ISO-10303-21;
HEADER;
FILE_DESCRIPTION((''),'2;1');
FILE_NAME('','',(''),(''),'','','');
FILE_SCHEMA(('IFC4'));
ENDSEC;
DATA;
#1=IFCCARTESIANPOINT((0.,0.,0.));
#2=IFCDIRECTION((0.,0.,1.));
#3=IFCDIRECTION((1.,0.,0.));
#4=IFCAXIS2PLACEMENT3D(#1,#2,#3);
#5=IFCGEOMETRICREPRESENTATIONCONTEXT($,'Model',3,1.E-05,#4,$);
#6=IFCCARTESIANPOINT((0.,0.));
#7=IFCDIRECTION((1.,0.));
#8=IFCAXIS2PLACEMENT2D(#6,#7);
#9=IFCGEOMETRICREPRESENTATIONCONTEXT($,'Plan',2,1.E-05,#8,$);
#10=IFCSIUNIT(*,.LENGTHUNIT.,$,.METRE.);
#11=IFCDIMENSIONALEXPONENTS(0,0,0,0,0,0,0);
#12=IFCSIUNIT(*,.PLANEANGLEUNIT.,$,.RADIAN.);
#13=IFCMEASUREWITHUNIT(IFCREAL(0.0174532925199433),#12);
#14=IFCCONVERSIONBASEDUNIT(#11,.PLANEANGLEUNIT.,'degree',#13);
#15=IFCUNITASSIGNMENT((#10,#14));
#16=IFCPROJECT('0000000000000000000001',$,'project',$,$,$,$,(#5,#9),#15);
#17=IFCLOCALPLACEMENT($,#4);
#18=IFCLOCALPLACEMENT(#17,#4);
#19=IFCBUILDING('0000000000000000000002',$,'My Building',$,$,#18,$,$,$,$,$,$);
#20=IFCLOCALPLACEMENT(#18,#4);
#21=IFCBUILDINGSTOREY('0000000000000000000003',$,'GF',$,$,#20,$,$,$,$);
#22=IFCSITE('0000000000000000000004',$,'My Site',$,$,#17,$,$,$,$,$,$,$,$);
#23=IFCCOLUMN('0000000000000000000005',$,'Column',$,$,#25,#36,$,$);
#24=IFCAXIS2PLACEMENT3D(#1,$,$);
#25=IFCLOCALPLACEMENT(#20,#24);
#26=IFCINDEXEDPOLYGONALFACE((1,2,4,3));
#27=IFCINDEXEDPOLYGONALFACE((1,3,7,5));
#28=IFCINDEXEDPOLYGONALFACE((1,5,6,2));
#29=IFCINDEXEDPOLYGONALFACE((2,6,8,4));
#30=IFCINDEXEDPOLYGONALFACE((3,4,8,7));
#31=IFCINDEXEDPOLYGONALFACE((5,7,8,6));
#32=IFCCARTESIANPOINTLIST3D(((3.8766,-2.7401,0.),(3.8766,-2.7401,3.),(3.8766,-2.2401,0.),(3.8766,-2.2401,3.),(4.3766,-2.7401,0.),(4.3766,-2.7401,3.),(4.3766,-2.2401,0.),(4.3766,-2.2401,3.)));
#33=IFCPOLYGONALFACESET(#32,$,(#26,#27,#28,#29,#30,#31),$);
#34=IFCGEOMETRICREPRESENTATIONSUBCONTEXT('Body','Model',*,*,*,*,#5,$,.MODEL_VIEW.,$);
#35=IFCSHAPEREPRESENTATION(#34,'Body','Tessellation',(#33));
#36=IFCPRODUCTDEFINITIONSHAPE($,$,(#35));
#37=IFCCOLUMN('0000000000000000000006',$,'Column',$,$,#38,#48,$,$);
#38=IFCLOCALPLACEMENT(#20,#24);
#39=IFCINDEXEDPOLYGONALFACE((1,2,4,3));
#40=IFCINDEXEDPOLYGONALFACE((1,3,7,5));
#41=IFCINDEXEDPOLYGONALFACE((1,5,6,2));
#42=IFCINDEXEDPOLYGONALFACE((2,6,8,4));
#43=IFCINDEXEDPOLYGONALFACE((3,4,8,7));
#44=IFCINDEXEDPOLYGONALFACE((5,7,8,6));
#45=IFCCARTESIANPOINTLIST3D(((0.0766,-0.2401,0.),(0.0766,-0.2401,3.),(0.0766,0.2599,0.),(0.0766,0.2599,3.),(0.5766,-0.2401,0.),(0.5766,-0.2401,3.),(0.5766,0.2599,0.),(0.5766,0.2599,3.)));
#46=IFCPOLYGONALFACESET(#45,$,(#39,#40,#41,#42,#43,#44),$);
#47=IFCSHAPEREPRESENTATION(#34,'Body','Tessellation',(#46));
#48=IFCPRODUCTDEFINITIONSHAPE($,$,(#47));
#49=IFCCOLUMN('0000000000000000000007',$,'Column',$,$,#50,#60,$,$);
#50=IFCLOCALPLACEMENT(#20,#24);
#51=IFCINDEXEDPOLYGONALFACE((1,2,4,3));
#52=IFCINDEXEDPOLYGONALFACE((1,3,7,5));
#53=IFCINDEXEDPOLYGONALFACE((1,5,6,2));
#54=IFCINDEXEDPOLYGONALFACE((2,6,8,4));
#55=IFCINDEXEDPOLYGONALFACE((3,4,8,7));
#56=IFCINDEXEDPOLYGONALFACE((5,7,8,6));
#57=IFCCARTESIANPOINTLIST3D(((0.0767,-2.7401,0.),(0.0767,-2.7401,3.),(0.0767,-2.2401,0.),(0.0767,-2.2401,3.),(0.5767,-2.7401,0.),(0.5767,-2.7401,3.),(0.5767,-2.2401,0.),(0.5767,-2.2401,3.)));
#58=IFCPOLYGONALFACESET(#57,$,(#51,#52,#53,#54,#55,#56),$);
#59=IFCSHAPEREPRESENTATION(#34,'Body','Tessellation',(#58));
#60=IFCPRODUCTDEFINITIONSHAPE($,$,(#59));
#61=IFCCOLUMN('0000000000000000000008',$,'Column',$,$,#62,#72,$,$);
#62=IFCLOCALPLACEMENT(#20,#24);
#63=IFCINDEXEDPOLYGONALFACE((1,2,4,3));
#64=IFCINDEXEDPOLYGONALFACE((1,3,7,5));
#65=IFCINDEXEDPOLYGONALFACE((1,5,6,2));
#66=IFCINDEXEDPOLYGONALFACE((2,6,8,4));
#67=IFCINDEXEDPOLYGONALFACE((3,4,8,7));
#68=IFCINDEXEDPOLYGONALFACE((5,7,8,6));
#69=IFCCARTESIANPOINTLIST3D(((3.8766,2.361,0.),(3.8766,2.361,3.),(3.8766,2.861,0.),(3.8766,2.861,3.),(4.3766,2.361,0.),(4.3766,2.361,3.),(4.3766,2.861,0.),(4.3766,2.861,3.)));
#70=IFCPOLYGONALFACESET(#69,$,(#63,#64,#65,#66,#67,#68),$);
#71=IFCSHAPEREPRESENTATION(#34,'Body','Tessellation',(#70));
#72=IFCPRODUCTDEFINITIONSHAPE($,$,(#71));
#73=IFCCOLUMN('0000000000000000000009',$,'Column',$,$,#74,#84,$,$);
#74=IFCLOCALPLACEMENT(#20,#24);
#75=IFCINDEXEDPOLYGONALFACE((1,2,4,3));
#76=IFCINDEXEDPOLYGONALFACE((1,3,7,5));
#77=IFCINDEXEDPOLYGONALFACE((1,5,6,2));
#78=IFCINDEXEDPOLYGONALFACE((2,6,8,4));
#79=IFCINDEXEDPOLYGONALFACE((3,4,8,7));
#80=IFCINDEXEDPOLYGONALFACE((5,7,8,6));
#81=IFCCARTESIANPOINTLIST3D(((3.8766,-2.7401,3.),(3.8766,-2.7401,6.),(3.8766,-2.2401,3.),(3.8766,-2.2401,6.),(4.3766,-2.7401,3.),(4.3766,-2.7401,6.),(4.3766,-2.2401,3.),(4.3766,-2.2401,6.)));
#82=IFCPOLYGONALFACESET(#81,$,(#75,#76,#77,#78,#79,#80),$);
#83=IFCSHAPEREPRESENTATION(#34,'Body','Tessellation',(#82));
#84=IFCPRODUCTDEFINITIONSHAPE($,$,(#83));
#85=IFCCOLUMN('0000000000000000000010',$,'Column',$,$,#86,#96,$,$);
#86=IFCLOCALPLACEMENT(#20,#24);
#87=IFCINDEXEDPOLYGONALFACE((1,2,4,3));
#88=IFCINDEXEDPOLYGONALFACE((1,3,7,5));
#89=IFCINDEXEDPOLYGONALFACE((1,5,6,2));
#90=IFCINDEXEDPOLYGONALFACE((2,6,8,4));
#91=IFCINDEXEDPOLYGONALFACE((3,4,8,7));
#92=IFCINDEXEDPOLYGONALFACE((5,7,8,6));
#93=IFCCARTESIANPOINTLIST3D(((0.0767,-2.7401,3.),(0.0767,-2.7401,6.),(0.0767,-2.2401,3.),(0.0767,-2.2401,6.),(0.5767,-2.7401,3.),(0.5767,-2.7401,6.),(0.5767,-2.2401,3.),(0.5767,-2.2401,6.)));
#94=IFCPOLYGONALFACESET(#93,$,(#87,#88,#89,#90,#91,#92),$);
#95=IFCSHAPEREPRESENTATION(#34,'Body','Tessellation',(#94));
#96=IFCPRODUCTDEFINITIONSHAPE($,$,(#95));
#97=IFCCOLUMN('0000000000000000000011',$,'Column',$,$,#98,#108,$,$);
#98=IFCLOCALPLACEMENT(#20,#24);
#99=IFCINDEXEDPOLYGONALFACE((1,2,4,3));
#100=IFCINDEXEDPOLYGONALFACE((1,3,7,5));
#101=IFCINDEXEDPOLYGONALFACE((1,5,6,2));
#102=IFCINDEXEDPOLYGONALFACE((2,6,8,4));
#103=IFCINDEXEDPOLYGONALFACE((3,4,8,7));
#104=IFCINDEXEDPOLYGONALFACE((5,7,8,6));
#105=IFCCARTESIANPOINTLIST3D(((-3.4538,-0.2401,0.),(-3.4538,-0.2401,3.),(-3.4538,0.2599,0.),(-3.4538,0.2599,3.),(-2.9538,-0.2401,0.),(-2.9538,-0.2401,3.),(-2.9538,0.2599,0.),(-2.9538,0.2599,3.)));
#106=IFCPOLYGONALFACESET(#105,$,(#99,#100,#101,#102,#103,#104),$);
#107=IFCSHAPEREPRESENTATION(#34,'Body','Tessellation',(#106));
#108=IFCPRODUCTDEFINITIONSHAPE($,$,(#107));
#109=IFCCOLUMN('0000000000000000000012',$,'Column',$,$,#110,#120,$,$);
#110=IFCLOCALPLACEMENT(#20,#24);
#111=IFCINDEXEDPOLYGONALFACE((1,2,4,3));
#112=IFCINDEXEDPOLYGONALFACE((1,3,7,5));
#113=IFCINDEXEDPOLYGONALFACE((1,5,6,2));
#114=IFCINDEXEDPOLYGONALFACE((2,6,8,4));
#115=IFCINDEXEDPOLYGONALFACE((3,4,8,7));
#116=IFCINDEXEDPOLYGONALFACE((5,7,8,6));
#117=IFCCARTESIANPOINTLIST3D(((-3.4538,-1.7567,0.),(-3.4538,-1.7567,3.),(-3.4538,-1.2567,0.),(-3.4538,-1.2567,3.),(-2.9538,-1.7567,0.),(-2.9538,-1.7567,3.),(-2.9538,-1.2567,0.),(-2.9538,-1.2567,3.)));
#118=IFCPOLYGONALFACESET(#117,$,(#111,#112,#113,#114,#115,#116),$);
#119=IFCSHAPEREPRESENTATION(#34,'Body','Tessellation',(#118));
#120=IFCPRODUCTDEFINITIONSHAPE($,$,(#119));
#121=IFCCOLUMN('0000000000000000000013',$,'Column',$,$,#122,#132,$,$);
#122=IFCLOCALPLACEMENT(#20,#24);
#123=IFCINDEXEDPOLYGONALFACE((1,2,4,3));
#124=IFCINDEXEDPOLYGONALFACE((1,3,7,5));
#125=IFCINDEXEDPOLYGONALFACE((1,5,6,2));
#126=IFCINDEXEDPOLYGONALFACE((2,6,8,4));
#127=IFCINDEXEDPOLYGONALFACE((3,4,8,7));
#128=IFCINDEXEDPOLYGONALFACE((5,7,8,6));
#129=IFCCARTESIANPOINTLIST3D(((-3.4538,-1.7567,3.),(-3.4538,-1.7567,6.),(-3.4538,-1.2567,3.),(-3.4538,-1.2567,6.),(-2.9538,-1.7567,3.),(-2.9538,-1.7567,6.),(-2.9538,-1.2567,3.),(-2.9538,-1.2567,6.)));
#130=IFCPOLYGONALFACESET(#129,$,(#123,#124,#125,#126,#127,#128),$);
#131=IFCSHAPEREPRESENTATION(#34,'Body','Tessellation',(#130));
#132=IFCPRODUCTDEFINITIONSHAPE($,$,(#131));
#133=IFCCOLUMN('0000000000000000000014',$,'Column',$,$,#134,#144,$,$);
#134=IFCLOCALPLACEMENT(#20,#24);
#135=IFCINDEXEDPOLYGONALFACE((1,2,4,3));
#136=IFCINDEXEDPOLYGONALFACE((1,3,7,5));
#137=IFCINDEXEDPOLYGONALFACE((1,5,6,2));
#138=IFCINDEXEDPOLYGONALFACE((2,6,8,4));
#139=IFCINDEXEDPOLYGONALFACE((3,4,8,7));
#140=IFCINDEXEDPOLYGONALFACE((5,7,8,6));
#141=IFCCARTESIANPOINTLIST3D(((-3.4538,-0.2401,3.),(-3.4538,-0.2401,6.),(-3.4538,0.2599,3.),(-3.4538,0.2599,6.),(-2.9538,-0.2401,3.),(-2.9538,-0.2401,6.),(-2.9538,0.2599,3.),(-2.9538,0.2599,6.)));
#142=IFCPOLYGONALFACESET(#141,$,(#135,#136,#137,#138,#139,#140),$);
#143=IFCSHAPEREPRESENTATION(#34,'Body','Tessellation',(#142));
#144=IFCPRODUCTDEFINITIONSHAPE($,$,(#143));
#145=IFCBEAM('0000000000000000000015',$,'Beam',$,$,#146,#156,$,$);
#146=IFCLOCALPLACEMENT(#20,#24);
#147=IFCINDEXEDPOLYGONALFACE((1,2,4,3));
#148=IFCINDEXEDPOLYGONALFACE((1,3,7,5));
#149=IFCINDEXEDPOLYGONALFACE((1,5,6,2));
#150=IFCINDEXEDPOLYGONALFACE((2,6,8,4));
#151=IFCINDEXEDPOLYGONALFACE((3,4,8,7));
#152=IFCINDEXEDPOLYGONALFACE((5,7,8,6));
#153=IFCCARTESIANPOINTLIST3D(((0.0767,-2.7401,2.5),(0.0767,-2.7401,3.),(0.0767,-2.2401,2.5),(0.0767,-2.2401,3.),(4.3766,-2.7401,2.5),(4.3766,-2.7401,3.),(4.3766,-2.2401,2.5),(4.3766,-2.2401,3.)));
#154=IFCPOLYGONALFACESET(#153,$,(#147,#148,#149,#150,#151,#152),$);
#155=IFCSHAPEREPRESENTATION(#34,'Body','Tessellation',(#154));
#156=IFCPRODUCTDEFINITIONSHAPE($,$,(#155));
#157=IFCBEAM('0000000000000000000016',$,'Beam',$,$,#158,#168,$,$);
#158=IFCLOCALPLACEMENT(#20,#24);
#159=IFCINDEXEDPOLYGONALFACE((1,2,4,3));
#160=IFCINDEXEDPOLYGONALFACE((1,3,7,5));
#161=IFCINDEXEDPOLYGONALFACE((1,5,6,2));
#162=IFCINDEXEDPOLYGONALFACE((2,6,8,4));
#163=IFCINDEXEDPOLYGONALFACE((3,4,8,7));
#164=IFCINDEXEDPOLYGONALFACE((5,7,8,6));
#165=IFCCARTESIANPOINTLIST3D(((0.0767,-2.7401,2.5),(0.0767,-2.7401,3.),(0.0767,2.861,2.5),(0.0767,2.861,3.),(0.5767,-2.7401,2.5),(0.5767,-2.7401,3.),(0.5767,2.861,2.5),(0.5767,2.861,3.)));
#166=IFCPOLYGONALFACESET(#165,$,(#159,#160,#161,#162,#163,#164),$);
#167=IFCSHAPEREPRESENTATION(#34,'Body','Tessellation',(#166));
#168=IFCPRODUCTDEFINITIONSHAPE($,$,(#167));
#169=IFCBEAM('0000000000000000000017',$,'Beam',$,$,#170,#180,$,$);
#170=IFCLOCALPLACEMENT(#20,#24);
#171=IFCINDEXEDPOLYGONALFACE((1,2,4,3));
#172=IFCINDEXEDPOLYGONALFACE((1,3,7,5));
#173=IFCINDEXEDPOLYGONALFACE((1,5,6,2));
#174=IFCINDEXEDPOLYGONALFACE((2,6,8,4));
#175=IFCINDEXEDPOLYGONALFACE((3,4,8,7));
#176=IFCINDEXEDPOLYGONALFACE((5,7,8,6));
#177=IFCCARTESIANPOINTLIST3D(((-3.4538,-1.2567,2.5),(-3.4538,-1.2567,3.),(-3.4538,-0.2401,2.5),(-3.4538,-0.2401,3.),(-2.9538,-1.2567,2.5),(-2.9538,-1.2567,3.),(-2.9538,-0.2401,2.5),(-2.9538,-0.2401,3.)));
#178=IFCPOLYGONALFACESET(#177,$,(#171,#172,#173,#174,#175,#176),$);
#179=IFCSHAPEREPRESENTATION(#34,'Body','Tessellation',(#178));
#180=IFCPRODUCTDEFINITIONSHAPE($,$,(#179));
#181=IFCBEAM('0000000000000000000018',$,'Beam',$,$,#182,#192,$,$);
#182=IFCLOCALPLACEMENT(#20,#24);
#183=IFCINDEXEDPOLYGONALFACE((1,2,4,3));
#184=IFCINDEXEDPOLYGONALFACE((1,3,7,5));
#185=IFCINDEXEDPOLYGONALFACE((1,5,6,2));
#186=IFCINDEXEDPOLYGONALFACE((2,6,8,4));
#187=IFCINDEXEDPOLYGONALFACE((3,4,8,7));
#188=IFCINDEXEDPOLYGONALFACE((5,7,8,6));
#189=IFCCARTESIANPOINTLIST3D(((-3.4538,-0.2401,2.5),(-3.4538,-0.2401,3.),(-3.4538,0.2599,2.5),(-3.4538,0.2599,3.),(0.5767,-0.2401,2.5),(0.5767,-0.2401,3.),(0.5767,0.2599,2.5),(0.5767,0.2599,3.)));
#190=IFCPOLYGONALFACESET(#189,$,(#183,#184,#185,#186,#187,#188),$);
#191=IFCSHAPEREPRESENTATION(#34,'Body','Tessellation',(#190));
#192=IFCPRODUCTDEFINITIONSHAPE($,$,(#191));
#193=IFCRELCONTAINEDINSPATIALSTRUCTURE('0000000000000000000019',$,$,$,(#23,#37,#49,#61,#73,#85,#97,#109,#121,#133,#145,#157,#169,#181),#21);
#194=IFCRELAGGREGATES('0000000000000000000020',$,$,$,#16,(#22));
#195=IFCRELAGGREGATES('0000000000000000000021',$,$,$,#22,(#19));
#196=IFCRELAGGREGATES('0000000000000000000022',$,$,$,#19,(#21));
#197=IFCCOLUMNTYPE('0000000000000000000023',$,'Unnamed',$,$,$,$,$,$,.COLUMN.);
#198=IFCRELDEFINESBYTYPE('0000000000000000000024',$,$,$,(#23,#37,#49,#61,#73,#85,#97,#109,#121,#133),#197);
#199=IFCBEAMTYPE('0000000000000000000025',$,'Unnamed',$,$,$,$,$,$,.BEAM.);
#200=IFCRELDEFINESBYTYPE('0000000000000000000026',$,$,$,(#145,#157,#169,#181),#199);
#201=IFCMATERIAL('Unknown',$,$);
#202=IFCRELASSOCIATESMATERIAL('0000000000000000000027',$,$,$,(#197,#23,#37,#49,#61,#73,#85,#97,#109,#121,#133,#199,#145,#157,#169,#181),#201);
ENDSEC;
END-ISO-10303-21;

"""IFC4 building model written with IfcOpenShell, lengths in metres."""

from ifc_helpers import new_model, entity, si_unit, converted_unit, frame, origin_with_axes, origin_2d_with_axis, place, context, subcontext, project, spatial, rectangle, extrude, material, material_profile, profile_set, profile_usage, type_object, element, save


model = new_model("IFC4")

# Units and contexts
model_context = context("Model", 3, precision=1e-05, world=origin_with_axes())
plan_context = context("Plan", 2, precision=1e-05, world=origin_2d_with_axis())
body_context_1 = subcontext(model_context, "Body", "Model", "MODEL_VIEW")
ifc_project = project(units=[si_unit("LENGTHUNIT", "METRE"), converted_unit("PLANEANGLEUNIT", "degree", entity("IfcReal", 0.0174532925199433), si_unit("PLANEANGLEUNIT", "RADIAN"), dimensions=[0, 0, 0, 0, 0, 0, 0])], contexts=[model_context, plan_context])

# Site, building, storey
site_placement = place(None, origin_with_axes())
site = spatial("IfcSite", under=ifc_project, at=site_placement, Name="My Site")
building_placement = place(site_placement, origin_with_axes())
building = spatial("IfcBuilding", under=site, at=building_placement, Name="My Building")
storey_placement = place(building_placement, origin_with_axes())
storey = spatial("IfcBuildingStorey", under=building, at=storey_placement, Name="GF")

# Columns
ifc_material_1 = material(Name="Unknown")
ifc_material_profile_1 = material_profile(ifc_material_1, rectangle(XDim=0.5, YDim=0.5))
ifc_profile_set_1 = profile_set([ifc_material_profile_1])
ifc_profile_usage_1 = profile_usage(ifc_profile_set_1, cardinal=5)
column_type = type_object("IfcColumnType", Name="Unnamed", PredefinedType="COLUMN", material=ifc_profile_set_1)
column_1_placement = place(storey_placement, frame((4.1266, -2.4901, 0.0), z_axis=(0.0, 0.0, 1.0), x_axis=(1.0, 0.0, 0.0)))
element("IfcColumn", 1, at=column_1_placement, inside=storey, type_object=column_type, material=ifc_profile_usage_1, Name="Column", context=body_context_1, shape_type="SweptSolid", body=[
    extrude(rectangle(XDim=0.5, YDim=0.5), origin_with_axes(), (0.0, 0.0, 1.0), 3.0),
])
ifc_profile_usage_2 = profile_usage(ifc_profile_set_1, cardinal=5)
column_2_placement = place(storey_placement, frame((0.3266, 0.0099, 0.0), z_axis=(0.0, 0.0, 1.0), x_axis=(1.0, 0.0, 0.0)))
element("IfcColumn", 2, at=column_2_placement, inside=storey, type_object=column_type, material=ifc_profile_usage_2, Name="Column", context=body_context_1, shape_type="SweptSolid", body=[
    extrude(rectangle(XDim=0.5, YDim=0.5), origin_with_axes(), (0.0, 0.0, 1.0), 3.0),
])
ifc_profile_usage_3 = profile_usage(ifc_profile_set_1, cardinal=5)
column_3_placement = place(storey_placement, frame((0.3267, -2.4901, 0.0), z_axis=(0.0, 0.0, 1.0), x_axis=(1.0, 0.0, 0.0)))
element("IfcColumn", 3, at=column_3_placement, inside=storey, type_object=column_type, material=ifc_profile_usage_3, Name="Column", context=body_context_1, shape_type="SweptSolid", body=[
    extrude(rectangle(XDim=0.5, YDim=0.5), origin_with_axes(), (0.0, 0.0, 1.0), 3.0),
])
ifc_profile_usage_4 = profile_usage(ifc_profile_set_1, cardinal=5)
column_4_placement = place(storey_placement, frame((4.1266, 2.611, 0.0), z_axis=(0.0, 0.0, 1.0), x_axis=(1.0, 0.0, 0.0)))
element("IfcColumn", 4, at=column_4_placement, inside=storey, type_object=column_type, material=ifc_profile_usage_4, Name="Column", context=body_context_1, shape_type="SweptSolid", body=[
    extrude(rectangle(XDim=0.5, YDim=0.5), origin_with_axes(), (0.0, 0.0, 1.0), 3.0),
])
ifc_profile_usage_5 = profile_usage(ifc_profile_set_1, cardinal=5)
column_5_placement = place(storey_placement, frame((4.1266, -2.4901, 3.0), z_axis=(0.0, 0.0, 1.0), x_axis=(1.0, 0.0, 0.0)))
element("IfcColumn", 5, at=column_5_placement, inside=storey, type_object=column_type, material=ifc_profile_usage_5, Name="Column", context=body_context_1, shape_type="SweptSolid", body=[
    extrude(rectangle(XDim=0.5, YDim=0.5), origin_with_axes(), (0.0, 0.0, 1.0), 3.0),
])
ifc_profile_usage_6 = profile_usage(ifc_profile_set_1, cardinal=5)
column_6_placement = place(storey_placement, frame((0.3267, -2.4901, 3.0), z_axis=(0.0, 0.0, 1.0), x_axis=(1.0, 0.0, 0.0)))
element("IfcColumn", 6, at=column_6_placement, inside=storey, type_object=column_type, material=ifc_profile_usage_6, Name="Column", context=body_context_1, shape_type="SweptSolid", body=[
    extrude(rectangle(XDim=0.5, YDim=0.5), origin_with_axes(), (0.0, 0.0, 1.0), 3.0),
])
ifc_profile_usage_7 = profile_usage(ifc_profile_set_1, cardinal=5)
column_7_placement = place(storey_placement, frame((-3.2038, 0.0099, 0.0), z_axis=(0.0, 0.0, 1.0), x_axis=(1.0, 0.0, 0.0)))
element("IfcColumn", 7, at=column_7_placement, inside=storey, type_object=column_type, material=ifc_profile_usage_7, Name="Column", context=body_context_1, shape_type="SweptSolid", body=[
    extrude(rectangle(XDim=0.5, YDim=0.5), origin_with_axes(), (0.0, 0.0, 1.0), 3.0),
])
ifc_profile_usage_8 = profile_usage(ifc_profile_set_1, cardinal=5)
column_8_placement = place(storey_placement, frame((-3.2038, -1.5067, 0.0), z_axis=(0.0, 0.0, 1.0), x_axis=(1.0, 0.0, 0.0)))
element("IfcColumn", 8, at=column_8_placement, inside=storey, type_object=column_type, material=ifc_profile_usage_8, Name="Column", context=body_context_1, shape_type="SweptSolid", body=[
    extrude(rectangle(XDim=0.5, YDim=0.5), origin_with_axes(), (0.0, 0.0, 1.0), 3.0),
])
ifc_profile_usage_9 = profile_usage(ifc_profile_set_1, cardinal=5)
column_9_placement = place(storey_placement, frame((-3.2038, -1.5067, 3.0), z_axis=(0.0, 0.0, 1.0), x_axis=(1.0, 0.0, 0.0)))
element("IfcColumn", 9, at=column_9_placement, inside=storey, type_object=column_type, material=ifc_profile_usage_9, Name="Column", context=body_context_1, shape_type="SweptSolid", body=[
    extrude(rectangle(XDim=0.5, YDim=0.5), origin_with_axes(), (0.0, 0.0, 1.0), 3.0),
])
ifc_profile_usage_10 = profile_usage(ifc_profile_set_1, cardinal=5)
column_10_placement = place(storey_placement, frame((-3.2038, 0.0099, 3.0), z_axis=(0.0, 0.0, 1.0), x_axis=(1.0, 0.0, 0.0)))
element("IfcColumn", 10, at=column_10_placement, inside=storey, type_object=column_type, material=ifc_profile_usage_10, Name="Column", context=body_context_1, shape_type="SweptSolid", body=[
    extrude(rectangle(XDim=0.5, YDim=0.5), origin_with_axes(), (0.0, 0.0, 1.0), 3.0),
])

# Beams
ifc_material_profile_2 = material_profile(ifc_material_1, rectangle(XDim=0.5, YDim=0.5))
ifc_profile_set_2 = profile_set([ifc_material_profile_2])
ifc_profile_usage_11 = profile_usage(ifc_profile_set_2, cardinal=7)
beam_type = type_object("IfcBeamType", Name="Unnamed", PredefinedType="BEAM", material=ifc_profile_set_2)
beam_1_placement = place(storey_placement, frame((0.0767, -2.2401, 3.0), z_axis=(1.0, 0.0, 0.0), x_axis=(0.0, 1.0, 0.0)))
element("IfcBeam", 11, at=beam_1_placement, inside=storey, type_object=beam_type, material=ifc_profile_usage_11, Name="Beam", context=body_context_1, shape_type="SweptSolid", body=[
    extrude(rectangle(XDim=0.5, YDim=0.5), frame((-0.25, -0.25, 0.0), z_axis=(0.0, 0.0, 1.0), x_axis=(1.0, 0.0, 0.0)), (0.0, 0.0, 1.0), 4.2999),
])
ifc_profile_usage_12 = profile_usage(ifc_profile_set_2, cardinal=7)
beam_2_placement = place(storey_placement, frame((0.0767, -2.7401, 3.0), z_axis=(0.0, 1.0, 0.0), x_axis=(-1.0, 0.0, 0.0)))
element("IfcBeam", 12, at=beam_2_placement, inside=storey, type_object=beam_type, material=ifc_profile_usage_12, Name="Beam", context=body_context_1, shape_type="SweptSolid", body=[
    extrude(rectangle(XDim=0.5, YDim=0.5), frame((-0.25, -0.25, 0.0), z_axis=(0.0, 0.0, 1.0), x_axis=(1.0, 0.0, 0.0)), (0.0, 0.0, 1.0), 5.6011),
])
ifc_profile_usage_13 = profile_usage(ifc_profile_set_2, cardinal=7)
beam_3_placement = place(storey_placement, frame((-2.9538, -0.2401, 3.0), z_axis=(0.0, -1.0, 0.0), x_axis=(1.0, 0.0, 0.0)))
element("IfcBeam", 13, at=beam_3_placement, inside=storey, type_object=beam_type, material=ifc_profile_usage_13, Name="Beam", context=body_context_1, shape_type="SweptSolid", body=[
    extrude(rectangle(XDim=0.5, YDim=0.5), frame((-0.25, -0.25, 0.0), z_axis=(0.0, 0.0, 1.0), x_axis=(1.0, 0.0, 0.0)), (0.0, 0.0, 1.0), 1.0166),
])
ifc_profile_usage_14 = profile_usage(ifc_profile_set_2, cardinal=7)
beam_4_placement = place(storey_placement, frame((-3.4538, 0.2599, 3.0), z_axis=(1.0, 0.0, 0.0), x_axis=(0.0, 1.0, 0.0)))
element("IfcBeam", 14, at=beam_4_placement, inside=storey, type_object=beam_type, material=ifc_profile_usage_14, Name="Beam", context=body_context_1, shape_type="SweptSolid", body=[
    extrude(rectangle(XDim=0.5, YDim=0.5), frame((-0.25, -0.25, 0.0), z_axis=(0.0, 0.0, 1.0), x_axis=(1.0, 0.0, 0.0)), (0.0, 0.0, 1.0), 4.0306),
])

save(model, "model.ifc")
